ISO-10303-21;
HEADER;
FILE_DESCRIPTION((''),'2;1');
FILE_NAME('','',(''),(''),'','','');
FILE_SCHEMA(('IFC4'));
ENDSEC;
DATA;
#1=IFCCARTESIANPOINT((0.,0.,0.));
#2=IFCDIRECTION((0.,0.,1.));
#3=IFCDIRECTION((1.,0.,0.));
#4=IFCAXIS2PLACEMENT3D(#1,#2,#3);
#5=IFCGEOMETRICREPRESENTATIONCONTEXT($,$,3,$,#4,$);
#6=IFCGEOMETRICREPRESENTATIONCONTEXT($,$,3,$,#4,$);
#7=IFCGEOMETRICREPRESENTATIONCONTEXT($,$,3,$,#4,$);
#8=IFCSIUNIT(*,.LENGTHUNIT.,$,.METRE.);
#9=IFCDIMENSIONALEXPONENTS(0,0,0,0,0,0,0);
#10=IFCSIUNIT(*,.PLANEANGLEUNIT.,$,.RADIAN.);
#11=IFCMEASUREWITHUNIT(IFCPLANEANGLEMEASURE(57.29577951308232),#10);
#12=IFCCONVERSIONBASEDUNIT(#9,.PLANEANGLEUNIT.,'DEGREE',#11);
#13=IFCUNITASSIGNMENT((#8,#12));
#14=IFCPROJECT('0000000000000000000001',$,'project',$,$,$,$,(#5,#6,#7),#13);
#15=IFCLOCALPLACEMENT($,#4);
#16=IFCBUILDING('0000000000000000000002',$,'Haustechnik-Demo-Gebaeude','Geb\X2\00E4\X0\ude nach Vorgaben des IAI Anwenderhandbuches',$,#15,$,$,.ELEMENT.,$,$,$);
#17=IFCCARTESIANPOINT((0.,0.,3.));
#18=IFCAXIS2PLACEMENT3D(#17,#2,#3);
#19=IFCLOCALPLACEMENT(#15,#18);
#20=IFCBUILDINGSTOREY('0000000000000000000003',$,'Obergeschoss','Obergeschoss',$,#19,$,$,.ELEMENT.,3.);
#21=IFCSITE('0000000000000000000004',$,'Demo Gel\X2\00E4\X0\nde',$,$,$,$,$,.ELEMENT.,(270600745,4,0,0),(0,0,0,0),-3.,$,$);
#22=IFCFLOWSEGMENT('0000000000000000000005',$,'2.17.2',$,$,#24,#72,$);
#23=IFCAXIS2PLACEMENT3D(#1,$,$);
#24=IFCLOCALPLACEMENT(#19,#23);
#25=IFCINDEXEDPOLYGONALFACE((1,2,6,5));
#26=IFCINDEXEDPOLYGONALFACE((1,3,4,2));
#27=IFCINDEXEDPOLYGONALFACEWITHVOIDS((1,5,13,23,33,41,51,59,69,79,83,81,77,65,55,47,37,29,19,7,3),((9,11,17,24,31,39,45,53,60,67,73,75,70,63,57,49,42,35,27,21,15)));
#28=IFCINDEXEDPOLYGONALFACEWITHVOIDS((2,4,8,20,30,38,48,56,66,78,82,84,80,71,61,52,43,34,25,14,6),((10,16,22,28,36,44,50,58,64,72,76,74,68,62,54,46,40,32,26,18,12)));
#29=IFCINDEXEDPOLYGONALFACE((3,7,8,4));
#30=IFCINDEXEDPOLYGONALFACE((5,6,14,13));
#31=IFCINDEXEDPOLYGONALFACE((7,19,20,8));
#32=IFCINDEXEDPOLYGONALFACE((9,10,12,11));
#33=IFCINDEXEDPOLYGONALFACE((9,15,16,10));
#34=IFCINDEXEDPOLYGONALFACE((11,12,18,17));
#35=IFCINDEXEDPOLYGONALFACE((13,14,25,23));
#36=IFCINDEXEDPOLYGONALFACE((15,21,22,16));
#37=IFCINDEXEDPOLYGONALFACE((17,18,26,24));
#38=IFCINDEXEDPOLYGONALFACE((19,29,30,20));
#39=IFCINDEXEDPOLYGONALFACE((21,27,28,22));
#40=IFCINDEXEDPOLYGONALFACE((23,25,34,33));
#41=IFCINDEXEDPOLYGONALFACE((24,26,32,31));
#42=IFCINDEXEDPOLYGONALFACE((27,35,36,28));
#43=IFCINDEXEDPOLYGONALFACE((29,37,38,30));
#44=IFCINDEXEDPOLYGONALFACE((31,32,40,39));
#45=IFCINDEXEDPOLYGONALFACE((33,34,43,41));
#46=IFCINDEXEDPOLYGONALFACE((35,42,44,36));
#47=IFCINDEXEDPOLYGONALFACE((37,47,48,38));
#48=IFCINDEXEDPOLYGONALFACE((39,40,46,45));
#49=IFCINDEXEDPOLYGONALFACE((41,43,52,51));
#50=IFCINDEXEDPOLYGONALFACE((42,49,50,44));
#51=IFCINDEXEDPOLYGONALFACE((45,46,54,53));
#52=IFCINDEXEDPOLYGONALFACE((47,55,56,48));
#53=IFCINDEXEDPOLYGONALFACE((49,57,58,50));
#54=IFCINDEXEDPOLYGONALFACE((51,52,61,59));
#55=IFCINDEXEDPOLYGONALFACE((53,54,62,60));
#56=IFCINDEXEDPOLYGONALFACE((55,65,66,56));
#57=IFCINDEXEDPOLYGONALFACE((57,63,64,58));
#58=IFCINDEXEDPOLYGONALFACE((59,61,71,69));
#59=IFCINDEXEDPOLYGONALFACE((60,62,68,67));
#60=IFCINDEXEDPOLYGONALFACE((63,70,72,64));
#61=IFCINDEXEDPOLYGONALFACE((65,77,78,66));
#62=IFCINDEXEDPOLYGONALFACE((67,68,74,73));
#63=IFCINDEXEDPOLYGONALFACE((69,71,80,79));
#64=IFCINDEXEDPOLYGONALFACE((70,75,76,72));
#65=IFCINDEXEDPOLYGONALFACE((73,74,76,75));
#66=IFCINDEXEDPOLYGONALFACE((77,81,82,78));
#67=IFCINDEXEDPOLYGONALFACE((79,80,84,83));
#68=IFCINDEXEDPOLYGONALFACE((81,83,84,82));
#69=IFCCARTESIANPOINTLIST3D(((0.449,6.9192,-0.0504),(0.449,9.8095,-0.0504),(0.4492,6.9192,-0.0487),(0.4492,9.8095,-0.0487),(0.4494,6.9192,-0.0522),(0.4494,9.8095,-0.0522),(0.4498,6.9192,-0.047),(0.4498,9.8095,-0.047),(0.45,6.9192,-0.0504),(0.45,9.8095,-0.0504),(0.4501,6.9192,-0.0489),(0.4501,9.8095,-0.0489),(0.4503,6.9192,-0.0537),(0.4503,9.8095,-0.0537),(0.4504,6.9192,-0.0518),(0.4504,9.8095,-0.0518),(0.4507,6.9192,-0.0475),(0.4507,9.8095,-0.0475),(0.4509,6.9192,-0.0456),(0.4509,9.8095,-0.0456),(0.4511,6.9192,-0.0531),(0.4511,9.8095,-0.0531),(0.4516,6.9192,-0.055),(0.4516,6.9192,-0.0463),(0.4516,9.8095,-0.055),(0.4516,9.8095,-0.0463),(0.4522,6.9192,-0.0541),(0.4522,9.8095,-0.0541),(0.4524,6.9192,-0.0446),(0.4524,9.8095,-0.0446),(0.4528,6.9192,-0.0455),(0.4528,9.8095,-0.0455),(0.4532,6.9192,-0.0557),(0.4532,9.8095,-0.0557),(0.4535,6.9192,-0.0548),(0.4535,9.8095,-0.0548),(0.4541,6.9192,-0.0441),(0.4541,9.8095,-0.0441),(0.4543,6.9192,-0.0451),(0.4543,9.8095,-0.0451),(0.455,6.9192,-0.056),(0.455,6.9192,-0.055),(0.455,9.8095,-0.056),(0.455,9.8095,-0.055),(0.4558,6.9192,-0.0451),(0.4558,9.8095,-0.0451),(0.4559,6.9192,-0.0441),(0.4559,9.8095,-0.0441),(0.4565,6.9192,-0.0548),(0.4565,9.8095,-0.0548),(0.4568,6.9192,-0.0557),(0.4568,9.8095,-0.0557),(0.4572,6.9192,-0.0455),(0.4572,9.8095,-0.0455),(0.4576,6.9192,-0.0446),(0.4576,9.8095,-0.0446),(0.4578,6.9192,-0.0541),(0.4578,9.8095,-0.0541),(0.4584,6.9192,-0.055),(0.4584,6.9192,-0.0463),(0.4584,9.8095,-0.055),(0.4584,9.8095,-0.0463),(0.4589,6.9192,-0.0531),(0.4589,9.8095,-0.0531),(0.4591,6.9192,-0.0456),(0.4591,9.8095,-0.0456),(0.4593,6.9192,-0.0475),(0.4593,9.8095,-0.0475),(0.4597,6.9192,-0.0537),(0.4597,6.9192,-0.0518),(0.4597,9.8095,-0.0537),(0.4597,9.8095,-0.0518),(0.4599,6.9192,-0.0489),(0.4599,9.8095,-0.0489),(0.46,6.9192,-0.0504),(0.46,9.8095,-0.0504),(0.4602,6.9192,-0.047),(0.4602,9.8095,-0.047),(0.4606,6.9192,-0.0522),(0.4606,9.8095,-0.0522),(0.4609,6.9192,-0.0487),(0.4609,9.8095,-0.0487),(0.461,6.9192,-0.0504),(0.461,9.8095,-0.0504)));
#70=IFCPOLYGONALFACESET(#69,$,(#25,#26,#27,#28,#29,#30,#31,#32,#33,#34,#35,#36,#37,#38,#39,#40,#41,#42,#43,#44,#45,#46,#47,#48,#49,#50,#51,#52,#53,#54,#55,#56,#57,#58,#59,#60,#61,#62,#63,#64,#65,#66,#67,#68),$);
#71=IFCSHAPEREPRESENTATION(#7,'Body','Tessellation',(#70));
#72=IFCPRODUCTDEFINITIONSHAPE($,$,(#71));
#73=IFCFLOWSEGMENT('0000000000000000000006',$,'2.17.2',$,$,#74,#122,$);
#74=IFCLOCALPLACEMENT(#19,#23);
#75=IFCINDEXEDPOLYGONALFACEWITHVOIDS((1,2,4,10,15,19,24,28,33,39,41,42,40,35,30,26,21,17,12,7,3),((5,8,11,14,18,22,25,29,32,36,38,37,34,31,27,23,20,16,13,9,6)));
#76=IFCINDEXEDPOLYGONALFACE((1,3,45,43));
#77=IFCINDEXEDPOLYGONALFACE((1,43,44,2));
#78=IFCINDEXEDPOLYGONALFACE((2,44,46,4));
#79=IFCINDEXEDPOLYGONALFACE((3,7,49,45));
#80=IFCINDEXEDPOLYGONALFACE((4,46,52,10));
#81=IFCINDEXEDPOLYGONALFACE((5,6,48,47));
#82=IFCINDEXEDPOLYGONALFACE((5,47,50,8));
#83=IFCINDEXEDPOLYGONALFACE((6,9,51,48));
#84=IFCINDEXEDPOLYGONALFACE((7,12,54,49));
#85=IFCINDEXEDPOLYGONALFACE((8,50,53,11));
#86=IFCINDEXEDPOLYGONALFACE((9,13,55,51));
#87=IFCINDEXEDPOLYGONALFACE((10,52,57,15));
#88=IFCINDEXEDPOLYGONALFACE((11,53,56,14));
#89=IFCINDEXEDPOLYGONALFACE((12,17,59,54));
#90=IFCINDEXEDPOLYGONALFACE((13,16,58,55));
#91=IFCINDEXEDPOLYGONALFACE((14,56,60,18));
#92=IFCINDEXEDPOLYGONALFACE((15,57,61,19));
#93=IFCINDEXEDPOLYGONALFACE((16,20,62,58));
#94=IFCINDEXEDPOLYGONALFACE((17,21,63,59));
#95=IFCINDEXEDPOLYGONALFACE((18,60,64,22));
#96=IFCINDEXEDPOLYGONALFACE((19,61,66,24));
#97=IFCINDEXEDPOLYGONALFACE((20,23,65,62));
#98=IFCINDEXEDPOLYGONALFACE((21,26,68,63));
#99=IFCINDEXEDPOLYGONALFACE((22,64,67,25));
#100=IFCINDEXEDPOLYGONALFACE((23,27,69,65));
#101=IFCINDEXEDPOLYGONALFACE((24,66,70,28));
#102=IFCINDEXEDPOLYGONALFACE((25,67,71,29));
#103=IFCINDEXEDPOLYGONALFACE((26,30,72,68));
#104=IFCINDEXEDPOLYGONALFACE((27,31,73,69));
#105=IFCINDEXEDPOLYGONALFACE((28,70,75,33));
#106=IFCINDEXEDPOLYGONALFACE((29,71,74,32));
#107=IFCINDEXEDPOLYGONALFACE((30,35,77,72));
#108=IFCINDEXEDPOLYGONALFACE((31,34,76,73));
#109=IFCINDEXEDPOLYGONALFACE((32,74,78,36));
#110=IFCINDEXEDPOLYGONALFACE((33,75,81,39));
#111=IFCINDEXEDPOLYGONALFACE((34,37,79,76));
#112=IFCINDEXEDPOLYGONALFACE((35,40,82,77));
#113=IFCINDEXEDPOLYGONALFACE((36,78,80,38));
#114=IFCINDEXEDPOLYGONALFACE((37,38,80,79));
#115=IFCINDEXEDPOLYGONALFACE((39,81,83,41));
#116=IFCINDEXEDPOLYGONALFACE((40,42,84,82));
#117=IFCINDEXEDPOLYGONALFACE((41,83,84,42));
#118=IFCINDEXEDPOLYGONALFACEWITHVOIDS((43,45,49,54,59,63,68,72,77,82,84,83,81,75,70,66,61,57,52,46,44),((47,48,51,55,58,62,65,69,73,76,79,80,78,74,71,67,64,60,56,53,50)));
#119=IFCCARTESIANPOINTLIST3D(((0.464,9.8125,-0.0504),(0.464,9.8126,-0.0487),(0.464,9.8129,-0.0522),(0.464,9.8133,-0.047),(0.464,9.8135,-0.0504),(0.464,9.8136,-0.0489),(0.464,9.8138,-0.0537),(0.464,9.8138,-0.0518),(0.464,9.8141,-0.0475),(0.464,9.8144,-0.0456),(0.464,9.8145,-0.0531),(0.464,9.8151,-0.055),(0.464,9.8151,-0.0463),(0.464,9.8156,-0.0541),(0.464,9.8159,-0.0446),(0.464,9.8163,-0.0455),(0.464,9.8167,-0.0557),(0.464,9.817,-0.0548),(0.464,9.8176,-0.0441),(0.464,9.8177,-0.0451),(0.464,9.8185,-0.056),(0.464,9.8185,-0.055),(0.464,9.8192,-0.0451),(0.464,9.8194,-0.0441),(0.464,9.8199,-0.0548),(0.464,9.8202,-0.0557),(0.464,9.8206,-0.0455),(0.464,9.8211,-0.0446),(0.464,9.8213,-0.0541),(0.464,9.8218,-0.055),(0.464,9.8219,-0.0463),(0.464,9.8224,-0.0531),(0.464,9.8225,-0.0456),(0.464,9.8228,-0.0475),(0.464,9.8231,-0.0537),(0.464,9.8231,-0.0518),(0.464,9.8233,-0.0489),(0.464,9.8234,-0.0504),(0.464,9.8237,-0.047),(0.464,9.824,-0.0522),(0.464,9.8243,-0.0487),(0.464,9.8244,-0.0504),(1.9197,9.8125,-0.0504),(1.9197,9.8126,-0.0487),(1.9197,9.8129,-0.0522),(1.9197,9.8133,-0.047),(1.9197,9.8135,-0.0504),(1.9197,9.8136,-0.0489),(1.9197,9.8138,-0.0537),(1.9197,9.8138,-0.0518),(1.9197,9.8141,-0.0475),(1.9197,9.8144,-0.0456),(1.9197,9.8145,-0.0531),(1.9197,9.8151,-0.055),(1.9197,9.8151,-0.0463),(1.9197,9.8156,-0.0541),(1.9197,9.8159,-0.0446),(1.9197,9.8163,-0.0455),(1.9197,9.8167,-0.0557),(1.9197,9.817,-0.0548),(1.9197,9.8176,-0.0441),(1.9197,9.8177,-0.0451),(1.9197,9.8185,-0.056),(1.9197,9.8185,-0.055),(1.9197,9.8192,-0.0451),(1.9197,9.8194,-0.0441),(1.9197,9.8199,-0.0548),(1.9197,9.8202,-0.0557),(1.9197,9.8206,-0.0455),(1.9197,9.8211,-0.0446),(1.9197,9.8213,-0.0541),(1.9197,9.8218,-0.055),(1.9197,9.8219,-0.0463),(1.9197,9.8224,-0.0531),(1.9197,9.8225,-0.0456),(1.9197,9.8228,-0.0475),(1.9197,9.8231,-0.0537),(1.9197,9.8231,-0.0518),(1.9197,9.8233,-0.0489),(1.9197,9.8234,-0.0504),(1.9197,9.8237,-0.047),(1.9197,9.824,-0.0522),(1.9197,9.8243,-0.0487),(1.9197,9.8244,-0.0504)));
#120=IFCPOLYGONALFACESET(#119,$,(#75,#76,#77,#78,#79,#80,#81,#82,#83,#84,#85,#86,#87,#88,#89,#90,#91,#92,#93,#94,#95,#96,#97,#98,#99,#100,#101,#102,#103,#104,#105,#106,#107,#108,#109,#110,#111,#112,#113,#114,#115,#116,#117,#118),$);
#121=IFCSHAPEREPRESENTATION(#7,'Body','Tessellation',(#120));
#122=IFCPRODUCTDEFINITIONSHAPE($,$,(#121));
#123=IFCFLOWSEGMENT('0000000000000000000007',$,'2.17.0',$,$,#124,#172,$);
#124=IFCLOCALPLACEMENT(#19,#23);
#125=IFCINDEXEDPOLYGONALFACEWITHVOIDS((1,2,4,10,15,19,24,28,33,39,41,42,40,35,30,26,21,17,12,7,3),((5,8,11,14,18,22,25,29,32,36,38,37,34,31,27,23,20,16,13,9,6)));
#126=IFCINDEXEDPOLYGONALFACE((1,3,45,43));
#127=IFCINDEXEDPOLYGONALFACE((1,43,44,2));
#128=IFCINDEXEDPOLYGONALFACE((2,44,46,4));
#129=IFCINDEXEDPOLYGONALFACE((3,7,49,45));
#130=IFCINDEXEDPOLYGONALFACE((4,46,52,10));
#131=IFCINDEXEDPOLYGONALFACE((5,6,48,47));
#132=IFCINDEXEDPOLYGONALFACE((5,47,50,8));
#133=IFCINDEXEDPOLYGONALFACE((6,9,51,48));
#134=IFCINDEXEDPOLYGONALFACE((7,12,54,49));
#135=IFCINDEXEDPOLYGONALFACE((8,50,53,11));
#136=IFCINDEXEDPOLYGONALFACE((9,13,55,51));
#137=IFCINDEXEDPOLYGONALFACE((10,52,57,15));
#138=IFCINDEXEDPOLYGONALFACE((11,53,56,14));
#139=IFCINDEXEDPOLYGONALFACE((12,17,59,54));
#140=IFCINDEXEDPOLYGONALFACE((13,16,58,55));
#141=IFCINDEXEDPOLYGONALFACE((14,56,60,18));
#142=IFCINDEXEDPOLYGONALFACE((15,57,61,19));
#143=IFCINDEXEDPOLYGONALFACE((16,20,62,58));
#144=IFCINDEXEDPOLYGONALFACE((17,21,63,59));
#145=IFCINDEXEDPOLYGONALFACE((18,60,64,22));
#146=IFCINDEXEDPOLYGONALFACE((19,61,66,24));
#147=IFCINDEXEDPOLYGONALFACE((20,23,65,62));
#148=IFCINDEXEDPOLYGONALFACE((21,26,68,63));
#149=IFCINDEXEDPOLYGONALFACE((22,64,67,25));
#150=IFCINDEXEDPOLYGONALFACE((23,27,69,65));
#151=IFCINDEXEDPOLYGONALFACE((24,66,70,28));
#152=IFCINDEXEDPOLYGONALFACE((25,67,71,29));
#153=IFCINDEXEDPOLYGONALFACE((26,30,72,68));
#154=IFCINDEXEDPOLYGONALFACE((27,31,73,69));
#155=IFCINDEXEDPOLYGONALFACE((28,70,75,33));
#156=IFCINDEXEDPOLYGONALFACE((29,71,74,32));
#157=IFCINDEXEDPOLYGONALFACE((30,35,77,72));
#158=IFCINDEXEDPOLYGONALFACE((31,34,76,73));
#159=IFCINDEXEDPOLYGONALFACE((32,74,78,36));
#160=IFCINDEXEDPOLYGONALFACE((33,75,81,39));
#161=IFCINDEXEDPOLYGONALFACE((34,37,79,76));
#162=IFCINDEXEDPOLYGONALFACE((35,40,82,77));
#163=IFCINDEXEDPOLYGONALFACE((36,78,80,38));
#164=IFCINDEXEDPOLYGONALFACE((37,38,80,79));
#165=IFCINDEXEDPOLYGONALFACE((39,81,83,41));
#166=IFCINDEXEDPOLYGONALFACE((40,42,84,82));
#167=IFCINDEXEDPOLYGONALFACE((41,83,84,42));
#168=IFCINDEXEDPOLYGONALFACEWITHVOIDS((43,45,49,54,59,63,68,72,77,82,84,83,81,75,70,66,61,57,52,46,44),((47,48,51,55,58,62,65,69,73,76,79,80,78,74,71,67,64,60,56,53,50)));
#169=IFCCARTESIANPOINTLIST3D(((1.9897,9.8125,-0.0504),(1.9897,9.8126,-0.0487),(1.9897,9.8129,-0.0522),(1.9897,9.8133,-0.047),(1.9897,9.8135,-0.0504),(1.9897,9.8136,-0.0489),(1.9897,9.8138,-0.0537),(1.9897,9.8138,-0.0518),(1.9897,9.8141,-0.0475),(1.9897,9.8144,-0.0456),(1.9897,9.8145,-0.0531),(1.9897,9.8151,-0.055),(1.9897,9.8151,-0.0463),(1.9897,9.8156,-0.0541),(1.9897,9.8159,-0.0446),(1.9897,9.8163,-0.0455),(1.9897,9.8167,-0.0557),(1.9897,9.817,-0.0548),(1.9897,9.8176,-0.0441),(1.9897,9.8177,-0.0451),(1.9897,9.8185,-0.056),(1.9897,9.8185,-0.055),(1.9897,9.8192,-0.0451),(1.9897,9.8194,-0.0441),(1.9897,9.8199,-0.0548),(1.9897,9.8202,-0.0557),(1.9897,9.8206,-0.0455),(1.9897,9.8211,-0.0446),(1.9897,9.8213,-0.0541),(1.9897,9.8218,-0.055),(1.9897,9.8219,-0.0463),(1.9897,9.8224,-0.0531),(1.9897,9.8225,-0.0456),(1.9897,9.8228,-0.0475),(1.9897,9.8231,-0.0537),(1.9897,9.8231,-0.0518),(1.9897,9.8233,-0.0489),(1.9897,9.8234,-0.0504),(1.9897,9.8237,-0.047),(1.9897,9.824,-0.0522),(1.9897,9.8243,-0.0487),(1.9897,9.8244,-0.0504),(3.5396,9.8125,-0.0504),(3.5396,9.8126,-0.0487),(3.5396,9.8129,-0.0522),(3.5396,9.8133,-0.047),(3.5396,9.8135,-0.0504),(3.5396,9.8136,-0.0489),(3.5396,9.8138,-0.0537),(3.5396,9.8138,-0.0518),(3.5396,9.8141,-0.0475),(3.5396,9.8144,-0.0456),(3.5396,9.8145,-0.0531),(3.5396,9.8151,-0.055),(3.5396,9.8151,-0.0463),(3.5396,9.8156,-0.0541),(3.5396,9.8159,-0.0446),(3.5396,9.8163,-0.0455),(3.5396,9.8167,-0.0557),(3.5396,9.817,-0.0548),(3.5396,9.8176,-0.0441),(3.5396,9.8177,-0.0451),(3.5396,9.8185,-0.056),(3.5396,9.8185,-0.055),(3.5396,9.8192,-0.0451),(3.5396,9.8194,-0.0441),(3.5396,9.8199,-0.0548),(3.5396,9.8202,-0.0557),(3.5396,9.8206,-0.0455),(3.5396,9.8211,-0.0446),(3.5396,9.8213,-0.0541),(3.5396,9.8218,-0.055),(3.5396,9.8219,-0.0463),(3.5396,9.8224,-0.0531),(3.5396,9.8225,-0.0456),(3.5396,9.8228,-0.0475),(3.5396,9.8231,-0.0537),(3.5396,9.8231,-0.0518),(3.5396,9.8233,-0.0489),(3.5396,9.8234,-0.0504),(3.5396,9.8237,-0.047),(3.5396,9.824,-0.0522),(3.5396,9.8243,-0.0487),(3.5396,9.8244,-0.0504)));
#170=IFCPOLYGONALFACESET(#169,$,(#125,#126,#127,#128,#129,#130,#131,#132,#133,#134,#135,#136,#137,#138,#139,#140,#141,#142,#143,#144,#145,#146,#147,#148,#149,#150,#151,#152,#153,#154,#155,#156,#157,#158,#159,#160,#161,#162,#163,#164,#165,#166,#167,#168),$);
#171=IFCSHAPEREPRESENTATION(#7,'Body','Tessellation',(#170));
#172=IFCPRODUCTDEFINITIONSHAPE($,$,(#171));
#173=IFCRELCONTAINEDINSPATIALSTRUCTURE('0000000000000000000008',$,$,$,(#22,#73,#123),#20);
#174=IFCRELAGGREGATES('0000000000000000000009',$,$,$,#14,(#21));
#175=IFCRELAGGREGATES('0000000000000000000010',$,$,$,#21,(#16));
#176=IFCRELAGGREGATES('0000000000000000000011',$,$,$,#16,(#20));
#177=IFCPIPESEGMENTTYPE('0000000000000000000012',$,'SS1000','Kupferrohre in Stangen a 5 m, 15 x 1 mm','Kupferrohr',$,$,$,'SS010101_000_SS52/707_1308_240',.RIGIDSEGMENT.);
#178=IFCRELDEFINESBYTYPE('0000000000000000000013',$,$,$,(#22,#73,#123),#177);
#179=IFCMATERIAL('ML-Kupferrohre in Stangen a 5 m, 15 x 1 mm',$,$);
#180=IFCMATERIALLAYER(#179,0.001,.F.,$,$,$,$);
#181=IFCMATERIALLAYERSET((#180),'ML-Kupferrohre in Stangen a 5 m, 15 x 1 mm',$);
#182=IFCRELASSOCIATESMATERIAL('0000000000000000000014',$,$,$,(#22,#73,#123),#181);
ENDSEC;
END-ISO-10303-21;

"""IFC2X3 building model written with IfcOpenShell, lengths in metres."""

from ifc_helpers import new_model, entity, si_unit, converted_unit, frame, origin_with_axes, origin_2d_with_axis, place, context, project, spatial, hollow_circle, extrude, material, layer, layer_set, layer_usage, type_object, element, save


model = new_model("IFC2X3")

# Units and contexts
context_of_model_1 = context(None, 3, world=origin_with_axes())
context_of_model_2 = context(None, 3, world=origin_with_axes())
context_of_model_3 = context(None, 3, world=origin_with_axes())
ifc_project = project(units=[si_unit("LENGTHUNIT", "METRE"), converted_unit("PLANEANGLEUNIT", "DEGREE", entity("IfcPlaneAngleMeasure", 57.29577951308232), si_unit("PLANEANGLEUNIT", "RADIAN"), dimensions=[0, 0, 0, 0, 0, 0, 0])], contexts=[context_of_model_1, context_of_model_2, context_of_model_3])

# Site, building, storey
site = spatial("IfcSite", under=ifc_project, Name="Demo Gelände", CompositionType="ELEMENT", RefLatitude=(270600745, 4, 0, 0), RefLongitude=(0, 0, 0, 0), RefElevation=-3.0)
building_placement = place(None, origin_with_axes())
building = spatial("IfcBuilding", under=site, at=building_placement, Name="Haustechnik-Demo-Gebaeude", Description="Gebäude nach Vorgaben des IAI Anwenderhandbuches", CompositionType="ELEMENT")
storey_placement = place(building_placement, frame((0.0, 0.0, 3.0), z_axis=(0.0, 0.0, 1.0), x_axis=(1.0, 0.0, 0.0)))
storey = spatial("IfcBuildingStorey", under=building, at=storey_placement, Name="Obergeschoss", Description="Obergeschoss", CompositionType="ELEMENT", Elevation=3.0)

# Flow segments
ifc_material = material(Name="ML-Kupferrohre in Stangen a 5 m, 15 x 1 mm")
ifc_layer = layer(ifc_material, 0.001, ventilated=False)
ifc_layer_set = layer_set([ifc_layer], Name="ML-Kupferrohre in Stangen a 5 m, 15 x 1 mm")
ifc_layer_usage = layer_usage(ifc_layer_set, "AXIS2", "POSITIVE", 0.0)
pipe_segment_type_1 = type_object("IfcPipeSegmentType", Name="SS1000", Description="Kupferrohre in Stangen a 5 m, 15 x 1 mm", ApplicableOccurrence="Kupferrohr", ElementType="SS010101_000_SS52/707_1308_240", PredefinedType="RIGIDSEGMENT")
flow_segment_1_placement = place(storey_placement, frame((0.455, 6.9192, -0.05), z_axis=(0.0, 1.0, 0.0), x_axis=(0.0, 0.0, -1.0)))
element("IfcFlowSegment", 1, at=flow_segment_1_placement, inside=storey, type_object=pipe_segment_type_1, material=ifc_layer_usage, Name="2.17.2", context=context_of_model_3, shape_type="SweptSolid", body=[
    extrude(hollow_circle(Radius=0.006, WallThickness=0.001, at=origin_2d_with_axis()), origin_with_axes(), (0.0, 0.0, 1.0), 2.8902),
])
flow_segment_2_placement = place(storey_placement, frame((0.464, 9.8185, -0.05), z_axis=(1.0, 0.0, 0.0), x_axis=(0.0, 0.0, -1.0)))
element("IfcFlowSegment", 2, at=flow_segment_2_placement, inside=storey, type_object=pipe_segment_type_1, material=ifc_layer_usage, Name="2.17.2", context=context_of_model_3, shape_type="SweptSolid", body=[
    extrude(hollow_circle(Radius=0.006, WallThickness=0.001, at=origin_2d_with_axis()), origin_with_axes(), (0.0, 0.0, 1.0), 1.4557),
])
flow_segment_3_placement = place(storey_placement, frame((1.9897, 9.8185, -0.05), z_axis=(1.0, 0.0, 0.0), x_axis=(0.0, 0.0, -1.0)))
element("IfcFlowSegment", 3, at=flow_segment_3_placement, inside=storey, type_object=pipe_segment_type_1, material=ifc_layer_usage, Name="2.17.0", context=context_of_model_3, shape_type="SweptSolid", body=[
    extrude(hollow_circle(Radius=0.006, WallThickness=0.001, at=origin_2d_with_axis()), origin_with_axes(), (0.0, 0.0, 1.0), 1.55),
])

save(model, "model.ifc")
